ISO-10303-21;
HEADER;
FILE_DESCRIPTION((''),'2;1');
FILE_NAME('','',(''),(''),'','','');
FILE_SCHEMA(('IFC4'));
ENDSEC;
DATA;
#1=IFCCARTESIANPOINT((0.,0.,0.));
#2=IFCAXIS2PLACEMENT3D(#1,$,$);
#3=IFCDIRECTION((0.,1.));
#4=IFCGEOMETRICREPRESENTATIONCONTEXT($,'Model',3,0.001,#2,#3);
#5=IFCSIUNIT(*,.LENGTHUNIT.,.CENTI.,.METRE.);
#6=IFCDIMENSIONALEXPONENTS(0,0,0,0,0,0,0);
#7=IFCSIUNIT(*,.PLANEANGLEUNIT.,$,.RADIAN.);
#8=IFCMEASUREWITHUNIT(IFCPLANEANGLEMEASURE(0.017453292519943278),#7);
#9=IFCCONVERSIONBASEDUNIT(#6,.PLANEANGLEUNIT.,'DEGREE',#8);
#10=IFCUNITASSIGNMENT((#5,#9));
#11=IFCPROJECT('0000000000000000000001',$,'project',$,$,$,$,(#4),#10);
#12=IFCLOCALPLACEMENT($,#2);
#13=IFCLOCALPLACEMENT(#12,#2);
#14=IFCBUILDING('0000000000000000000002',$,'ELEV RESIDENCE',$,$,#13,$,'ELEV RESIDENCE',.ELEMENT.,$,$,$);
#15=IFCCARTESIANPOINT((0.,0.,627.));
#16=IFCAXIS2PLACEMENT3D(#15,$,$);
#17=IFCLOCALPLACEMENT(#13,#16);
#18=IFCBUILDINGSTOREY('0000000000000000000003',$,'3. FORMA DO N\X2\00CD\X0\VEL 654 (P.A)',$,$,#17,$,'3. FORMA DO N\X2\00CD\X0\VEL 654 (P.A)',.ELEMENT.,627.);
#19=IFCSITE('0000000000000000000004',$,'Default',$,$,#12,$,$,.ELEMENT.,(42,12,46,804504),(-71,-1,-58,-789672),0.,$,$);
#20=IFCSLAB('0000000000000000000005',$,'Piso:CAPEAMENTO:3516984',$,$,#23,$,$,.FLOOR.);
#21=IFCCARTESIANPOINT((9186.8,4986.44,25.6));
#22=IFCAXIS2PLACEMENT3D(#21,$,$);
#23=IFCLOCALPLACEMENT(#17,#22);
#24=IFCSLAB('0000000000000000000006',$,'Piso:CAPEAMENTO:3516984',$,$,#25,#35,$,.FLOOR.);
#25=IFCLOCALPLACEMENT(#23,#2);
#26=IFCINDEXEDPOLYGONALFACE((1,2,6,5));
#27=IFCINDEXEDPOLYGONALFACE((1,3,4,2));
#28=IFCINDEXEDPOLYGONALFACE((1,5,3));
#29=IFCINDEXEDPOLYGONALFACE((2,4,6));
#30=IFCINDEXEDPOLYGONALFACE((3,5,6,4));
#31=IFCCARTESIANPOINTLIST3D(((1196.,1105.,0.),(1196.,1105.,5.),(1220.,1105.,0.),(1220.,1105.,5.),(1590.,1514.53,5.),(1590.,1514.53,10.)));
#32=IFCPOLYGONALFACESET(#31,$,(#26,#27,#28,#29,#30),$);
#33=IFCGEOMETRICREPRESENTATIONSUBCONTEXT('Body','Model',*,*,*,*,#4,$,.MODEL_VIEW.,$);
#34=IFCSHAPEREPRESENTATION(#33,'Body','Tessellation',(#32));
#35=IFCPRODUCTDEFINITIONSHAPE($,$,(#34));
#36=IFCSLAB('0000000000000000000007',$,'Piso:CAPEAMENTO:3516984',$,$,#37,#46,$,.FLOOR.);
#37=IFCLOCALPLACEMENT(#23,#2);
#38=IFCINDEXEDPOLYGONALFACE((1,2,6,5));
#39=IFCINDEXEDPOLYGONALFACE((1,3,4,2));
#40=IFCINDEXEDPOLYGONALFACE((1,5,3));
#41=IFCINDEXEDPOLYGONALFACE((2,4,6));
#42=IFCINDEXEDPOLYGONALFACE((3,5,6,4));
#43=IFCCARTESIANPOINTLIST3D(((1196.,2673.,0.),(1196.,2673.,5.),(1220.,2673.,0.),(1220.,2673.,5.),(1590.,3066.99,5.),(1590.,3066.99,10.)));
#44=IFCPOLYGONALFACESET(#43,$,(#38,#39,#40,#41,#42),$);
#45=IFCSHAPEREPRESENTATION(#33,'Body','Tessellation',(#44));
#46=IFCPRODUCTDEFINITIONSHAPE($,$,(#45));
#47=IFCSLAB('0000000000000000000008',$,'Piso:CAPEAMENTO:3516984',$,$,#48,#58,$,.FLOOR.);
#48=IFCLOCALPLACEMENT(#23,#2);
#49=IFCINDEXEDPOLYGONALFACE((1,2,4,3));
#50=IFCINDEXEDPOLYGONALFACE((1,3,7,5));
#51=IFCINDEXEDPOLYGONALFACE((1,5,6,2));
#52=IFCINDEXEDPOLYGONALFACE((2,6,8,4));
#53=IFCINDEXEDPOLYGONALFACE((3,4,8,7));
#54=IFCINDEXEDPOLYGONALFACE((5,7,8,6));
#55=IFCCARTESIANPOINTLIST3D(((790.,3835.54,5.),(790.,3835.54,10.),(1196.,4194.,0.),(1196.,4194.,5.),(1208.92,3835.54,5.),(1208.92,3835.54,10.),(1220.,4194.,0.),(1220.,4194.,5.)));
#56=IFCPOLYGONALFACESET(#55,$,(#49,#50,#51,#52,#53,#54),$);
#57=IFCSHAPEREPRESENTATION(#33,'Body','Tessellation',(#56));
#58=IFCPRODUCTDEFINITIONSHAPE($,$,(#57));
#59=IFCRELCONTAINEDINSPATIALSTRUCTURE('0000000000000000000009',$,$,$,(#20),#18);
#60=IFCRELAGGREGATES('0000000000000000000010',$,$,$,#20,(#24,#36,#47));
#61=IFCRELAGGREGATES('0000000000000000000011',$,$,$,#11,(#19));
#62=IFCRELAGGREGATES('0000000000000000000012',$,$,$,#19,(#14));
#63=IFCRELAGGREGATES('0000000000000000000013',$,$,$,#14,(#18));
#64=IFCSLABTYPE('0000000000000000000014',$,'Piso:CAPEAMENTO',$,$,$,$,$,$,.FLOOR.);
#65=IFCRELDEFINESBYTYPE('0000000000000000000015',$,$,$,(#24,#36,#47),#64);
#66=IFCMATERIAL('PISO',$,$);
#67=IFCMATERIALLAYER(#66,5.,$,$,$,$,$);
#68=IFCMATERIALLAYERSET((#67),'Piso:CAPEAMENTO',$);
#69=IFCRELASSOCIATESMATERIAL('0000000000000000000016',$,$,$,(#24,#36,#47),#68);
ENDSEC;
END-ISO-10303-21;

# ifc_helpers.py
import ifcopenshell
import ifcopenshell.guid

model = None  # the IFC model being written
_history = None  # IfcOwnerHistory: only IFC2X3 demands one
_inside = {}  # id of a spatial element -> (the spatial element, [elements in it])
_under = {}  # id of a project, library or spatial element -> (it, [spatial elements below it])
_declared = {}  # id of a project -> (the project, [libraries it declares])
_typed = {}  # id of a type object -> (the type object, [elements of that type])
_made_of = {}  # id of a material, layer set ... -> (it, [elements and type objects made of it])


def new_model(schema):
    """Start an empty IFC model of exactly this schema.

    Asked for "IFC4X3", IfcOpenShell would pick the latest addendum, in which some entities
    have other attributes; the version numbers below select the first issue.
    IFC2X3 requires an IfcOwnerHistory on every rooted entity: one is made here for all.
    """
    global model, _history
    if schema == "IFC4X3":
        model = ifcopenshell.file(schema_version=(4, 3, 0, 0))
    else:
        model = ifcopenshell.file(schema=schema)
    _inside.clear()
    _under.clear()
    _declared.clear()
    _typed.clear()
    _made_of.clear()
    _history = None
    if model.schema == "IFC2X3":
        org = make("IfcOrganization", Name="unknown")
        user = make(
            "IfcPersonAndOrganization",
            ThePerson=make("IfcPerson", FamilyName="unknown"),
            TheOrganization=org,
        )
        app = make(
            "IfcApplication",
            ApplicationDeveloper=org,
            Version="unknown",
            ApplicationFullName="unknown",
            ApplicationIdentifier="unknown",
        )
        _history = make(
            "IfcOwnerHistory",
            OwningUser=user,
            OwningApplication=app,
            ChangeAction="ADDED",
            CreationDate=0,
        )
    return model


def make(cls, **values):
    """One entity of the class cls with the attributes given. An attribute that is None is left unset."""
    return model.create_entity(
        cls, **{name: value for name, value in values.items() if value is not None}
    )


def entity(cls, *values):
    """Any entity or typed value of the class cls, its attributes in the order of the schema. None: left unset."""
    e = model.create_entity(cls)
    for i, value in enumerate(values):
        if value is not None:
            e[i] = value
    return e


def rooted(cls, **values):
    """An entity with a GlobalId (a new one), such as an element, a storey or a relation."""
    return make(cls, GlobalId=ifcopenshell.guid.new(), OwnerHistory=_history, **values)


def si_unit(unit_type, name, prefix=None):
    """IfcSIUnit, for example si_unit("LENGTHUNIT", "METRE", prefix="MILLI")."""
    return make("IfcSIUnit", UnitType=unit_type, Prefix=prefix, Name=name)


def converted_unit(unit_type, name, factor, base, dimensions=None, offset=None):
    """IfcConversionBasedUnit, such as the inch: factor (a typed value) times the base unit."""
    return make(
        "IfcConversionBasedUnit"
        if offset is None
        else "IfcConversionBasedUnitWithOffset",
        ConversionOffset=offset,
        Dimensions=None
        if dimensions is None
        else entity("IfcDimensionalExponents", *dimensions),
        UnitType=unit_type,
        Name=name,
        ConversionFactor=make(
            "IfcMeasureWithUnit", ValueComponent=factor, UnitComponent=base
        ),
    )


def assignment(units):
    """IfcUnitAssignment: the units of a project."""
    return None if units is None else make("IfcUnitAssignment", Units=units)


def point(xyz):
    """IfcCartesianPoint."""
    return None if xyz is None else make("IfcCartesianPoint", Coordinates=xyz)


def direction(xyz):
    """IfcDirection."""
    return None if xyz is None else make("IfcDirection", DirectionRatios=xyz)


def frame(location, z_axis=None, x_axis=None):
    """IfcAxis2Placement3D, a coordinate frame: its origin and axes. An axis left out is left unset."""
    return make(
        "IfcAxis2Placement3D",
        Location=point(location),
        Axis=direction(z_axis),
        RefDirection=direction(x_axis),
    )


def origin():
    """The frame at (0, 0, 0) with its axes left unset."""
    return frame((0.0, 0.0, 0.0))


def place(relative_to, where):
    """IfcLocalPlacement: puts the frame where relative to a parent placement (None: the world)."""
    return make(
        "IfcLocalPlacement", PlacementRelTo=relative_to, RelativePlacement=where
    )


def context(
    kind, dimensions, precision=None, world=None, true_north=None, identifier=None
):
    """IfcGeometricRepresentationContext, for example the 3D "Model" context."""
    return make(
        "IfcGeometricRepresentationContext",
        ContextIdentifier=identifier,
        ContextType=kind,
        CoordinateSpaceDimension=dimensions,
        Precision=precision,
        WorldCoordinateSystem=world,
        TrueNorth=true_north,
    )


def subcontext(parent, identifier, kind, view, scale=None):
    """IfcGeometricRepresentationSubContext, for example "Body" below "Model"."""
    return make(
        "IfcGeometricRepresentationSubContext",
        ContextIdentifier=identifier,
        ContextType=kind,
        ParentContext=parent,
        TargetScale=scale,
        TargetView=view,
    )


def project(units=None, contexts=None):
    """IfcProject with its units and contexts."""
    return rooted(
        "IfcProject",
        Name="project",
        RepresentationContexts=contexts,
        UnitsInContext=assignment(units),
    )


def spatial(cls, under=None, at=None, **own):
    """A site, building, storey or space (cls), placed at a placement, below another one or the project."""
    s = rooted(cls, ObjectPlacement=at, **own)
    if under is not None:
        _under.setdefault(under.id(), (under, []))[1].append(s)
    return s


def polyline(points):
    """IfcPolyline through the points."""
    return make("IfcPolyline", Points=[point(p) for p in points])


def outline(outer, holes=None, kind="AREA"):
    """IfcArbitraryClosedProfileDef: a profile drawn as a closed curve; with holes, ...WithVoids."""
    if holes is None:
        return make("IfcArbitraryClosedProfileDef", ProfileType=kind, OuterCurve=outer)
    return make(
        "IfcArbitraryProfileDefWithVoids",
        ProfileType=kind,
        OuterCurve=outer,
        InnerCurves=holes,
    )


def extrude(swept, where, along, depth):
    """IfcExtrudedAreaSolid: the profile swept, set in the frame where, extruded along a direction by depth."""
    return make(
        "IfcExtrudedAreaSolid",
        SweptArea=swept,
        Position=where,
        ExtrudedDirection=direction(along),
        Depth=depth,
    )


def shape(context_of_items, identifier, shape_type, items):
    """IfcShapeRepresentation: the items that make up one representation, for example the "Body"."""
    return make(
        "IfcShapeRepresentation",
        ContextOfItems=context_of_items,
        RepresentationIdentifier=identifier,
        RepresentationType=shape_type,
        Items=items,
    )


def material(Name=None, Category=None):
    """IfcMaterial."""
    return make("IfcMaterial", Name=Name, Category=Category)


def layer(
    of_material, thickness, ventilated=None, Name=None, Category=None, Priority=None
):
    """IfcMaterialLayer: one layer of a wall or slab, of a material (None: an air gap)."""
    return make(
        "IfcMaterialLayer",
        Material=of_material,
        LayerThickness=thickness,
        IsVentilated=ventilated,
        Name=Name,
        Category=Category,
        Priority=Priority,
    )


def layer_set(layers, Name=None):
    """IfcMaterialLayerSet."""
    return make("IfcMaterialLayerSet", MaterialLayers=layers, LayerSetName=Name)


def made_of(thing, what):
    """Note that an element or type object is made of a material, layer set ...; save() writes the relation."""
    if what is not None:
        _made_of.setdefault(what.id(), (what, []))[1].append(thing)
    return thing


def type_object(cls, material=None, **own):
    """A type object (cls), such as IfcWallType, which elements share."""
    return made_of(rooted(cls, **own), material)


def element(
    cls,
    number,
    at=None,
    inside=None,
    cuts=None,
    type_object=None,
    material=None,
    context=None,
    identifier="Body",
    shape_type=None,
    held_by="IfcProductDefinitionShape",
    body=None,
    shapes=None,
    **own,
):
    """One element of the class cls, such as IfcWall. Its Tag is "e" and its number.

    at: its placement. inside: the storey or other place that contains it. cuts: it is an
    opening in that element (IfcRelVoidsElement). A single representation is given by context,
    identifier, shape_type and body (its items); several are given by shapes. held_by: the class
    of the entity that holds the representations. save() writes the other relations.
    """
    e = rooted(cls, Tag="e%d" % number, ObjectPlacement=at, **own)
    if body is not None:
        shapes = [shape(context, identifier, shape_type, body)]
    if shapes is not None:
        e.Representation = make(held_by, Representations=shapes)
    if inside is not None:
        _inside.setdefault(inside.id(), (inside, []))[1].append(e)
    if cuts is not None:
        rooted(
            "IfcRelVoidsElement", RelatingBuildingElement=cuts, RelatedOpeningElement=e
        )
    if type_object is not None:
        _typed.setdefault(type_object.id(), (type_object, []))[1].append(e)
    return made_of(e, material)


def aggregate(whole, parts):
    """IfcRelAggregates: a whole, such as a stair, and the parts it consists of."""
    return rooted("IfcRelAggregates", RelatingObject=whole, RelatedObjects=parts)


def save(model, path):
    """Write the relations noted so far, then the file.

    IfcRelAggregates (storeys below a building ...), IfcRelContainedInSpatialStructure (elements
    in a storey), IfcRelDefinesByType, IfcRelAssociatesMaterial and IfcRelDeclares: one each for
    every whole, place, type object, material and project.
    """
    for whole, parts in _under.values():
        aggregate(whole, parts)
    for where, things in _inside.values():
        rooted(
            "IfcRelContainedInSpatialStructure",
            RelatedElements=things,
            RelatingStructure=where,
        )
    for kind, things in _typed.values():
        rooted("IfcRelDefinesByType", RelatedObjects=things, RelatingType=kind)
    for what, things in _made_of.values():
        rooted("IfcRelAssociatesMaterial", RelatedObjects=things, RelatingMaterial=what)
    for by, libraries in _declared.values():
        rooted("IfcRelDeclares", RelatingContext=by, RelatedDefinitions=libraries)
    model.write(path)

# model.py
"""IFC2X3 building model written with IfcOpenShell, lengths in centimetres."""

from ifc_helpers import new_model, entity, si_unit, converted_unit, direction, frame, origin, place, context, subcontext, project, spatial, polyline, outline, extrude, material, layer, layer_set, type_object, element, aggregate, save


model = new_model("IFC2X3")

# Units and contexts
model_context = context("Model", 3, precision=0.001, world=origin(), true_north=direction((0.0, 1.0)))
body_context = subcontext(model_context, "Body", "Model", "MODEL_VIEW")
ifc_project = project(units=[si_unit("LENGTHUNIT", "METRE", prefix="CENTI"), converted_unit("PLANEANGLEUNIT", "DEGREE", entity("IfcPlaneAngleMeasure", 0.017453292519943278), si_unit("PLANEANGLEUNIT", "RADIAN"), dimensions=[0, 0, 0, 0, 0, 0, 0])], contexts=[model_context])

# Site, building, storey
site_placement = place(None, origin())
site = spatial("IfcSite", under=ifc_project, at=site_placement, Name="Default", CompositionType="ELEMENT", RefLatitude=(42, 12, 46, 804504), RefLongitude=(-71, -1, -58, -789672), RefElevation=0.0)
building_placement = place(site_placement, origin())
building = spatial("IfcBuilding", under=site, at=building_placement, Name="ELEV RESIDENCE", LongName="ELEV RESIDENCE", CompositionType="ELEMENT")
storey_placement = place(building_placement, frame((0.0, 0.0, 627.0)))
storey = spatial("IfcBuildingStorey", under=building, at=storey_placement, Name="3. FORMA DO NÍVEL 654 (P.A)", LongName="3. FORMA DO NÍVEL 654 (P.A)", CompositionType="ELEMENT", Elevation=627.0)

# Slabs
slab_1_placement = place(storey_placement, frame((9186.8, 4986.44, 25.6)))
slab_1 = element("IfcSlab", 1, at=slab_1_placement, inside=storey, Name="Piso:CAPEAMENTO:3516984", PredefinedType="FLOOR")
ifc_material = material(Name="PISO")
ifc_layer = layer(ifc_material, 5.0)
ifc_layer_set = layer_set([ifc_layer], Name="Piso:CAPEAMENTO")
slab_type = type_object("IfcSlabType", Name="Piso:CAPEAMENTO", PredefinedType="FLOOR")
slab_2_placement = place(slab_1_placement, origin())
slab_2 = element("IfcSlab", 2, at=slab_2_placement, type_object=slab_type, material=ifc_layer_set, Name="Piso:CAPEAMENTO:3516984", PredefinedType="FLOOR", context=body_context, shape_type="SweptSolid", body=[
    extrude(outline(polyline([(-197.0, -204.78), (-173.0, -204.78), (197.0, 204.78), (-197.0, -204.78)])), frame((1393.0, 1309.76, 7.5), z_axis=(0.0, -0.012208, 0.999925), x_axis=(1.0, 0.0, 0.0)), (0.0, -0.012208, -0.999925), 5.0),
])
slab_3_placement = place(slab_1_placement, origin())
slab_3 = element("IfcSlab", 3, at=slab_3_placement, type_object=slab_type, material=ifc_layer_set, Name="Piso:CAPEAMENTO:3516984", PredefinedType="FLOOR", context=body_context, shape_type="SweptSolid", body=[
    extrude(outline(polyline([(-197.0, -197.01), (-173.0, -197.01), (197.0, 197.01), (-197.0, -197.01)])), frame((1393.0, 2870.0, 7.5), z_axis=(0.0, -0.012689, 0.999919), x_axis=(1.0, 0.0, 0.0)), (0.0, -0.012689, -0.999919), 5.0),
])
slab_4_placement = place(slab_1_placement, origin())
slab_4 = element("IfcSlab", 4, at=slab_4_placement, type_object=slab_type, material=ifc_layer_set, Name="Piso:CAPEAMENTO:3516984", PredefinedType="FLOOR", context=body_context, shape_type="SweptSolid", body=[
    extrude(outline(polyline([(215.0, 179.25), (191.0, 179.25), (-215.0, -179.25), (203.92, -179.25), (215.0, 179.25)])), frame((1005.0, 4014.77, 7.5), z_axis=(0.0, 0.013947, 0.999903), x_axis=(1.0, 0.0, 0.0)), (0.0, 0.013947, -0.999903), 5.0),
])
aggregate(slab_1, [slab_2, slab_3, slab_4])

save(model, "model.ifc")
